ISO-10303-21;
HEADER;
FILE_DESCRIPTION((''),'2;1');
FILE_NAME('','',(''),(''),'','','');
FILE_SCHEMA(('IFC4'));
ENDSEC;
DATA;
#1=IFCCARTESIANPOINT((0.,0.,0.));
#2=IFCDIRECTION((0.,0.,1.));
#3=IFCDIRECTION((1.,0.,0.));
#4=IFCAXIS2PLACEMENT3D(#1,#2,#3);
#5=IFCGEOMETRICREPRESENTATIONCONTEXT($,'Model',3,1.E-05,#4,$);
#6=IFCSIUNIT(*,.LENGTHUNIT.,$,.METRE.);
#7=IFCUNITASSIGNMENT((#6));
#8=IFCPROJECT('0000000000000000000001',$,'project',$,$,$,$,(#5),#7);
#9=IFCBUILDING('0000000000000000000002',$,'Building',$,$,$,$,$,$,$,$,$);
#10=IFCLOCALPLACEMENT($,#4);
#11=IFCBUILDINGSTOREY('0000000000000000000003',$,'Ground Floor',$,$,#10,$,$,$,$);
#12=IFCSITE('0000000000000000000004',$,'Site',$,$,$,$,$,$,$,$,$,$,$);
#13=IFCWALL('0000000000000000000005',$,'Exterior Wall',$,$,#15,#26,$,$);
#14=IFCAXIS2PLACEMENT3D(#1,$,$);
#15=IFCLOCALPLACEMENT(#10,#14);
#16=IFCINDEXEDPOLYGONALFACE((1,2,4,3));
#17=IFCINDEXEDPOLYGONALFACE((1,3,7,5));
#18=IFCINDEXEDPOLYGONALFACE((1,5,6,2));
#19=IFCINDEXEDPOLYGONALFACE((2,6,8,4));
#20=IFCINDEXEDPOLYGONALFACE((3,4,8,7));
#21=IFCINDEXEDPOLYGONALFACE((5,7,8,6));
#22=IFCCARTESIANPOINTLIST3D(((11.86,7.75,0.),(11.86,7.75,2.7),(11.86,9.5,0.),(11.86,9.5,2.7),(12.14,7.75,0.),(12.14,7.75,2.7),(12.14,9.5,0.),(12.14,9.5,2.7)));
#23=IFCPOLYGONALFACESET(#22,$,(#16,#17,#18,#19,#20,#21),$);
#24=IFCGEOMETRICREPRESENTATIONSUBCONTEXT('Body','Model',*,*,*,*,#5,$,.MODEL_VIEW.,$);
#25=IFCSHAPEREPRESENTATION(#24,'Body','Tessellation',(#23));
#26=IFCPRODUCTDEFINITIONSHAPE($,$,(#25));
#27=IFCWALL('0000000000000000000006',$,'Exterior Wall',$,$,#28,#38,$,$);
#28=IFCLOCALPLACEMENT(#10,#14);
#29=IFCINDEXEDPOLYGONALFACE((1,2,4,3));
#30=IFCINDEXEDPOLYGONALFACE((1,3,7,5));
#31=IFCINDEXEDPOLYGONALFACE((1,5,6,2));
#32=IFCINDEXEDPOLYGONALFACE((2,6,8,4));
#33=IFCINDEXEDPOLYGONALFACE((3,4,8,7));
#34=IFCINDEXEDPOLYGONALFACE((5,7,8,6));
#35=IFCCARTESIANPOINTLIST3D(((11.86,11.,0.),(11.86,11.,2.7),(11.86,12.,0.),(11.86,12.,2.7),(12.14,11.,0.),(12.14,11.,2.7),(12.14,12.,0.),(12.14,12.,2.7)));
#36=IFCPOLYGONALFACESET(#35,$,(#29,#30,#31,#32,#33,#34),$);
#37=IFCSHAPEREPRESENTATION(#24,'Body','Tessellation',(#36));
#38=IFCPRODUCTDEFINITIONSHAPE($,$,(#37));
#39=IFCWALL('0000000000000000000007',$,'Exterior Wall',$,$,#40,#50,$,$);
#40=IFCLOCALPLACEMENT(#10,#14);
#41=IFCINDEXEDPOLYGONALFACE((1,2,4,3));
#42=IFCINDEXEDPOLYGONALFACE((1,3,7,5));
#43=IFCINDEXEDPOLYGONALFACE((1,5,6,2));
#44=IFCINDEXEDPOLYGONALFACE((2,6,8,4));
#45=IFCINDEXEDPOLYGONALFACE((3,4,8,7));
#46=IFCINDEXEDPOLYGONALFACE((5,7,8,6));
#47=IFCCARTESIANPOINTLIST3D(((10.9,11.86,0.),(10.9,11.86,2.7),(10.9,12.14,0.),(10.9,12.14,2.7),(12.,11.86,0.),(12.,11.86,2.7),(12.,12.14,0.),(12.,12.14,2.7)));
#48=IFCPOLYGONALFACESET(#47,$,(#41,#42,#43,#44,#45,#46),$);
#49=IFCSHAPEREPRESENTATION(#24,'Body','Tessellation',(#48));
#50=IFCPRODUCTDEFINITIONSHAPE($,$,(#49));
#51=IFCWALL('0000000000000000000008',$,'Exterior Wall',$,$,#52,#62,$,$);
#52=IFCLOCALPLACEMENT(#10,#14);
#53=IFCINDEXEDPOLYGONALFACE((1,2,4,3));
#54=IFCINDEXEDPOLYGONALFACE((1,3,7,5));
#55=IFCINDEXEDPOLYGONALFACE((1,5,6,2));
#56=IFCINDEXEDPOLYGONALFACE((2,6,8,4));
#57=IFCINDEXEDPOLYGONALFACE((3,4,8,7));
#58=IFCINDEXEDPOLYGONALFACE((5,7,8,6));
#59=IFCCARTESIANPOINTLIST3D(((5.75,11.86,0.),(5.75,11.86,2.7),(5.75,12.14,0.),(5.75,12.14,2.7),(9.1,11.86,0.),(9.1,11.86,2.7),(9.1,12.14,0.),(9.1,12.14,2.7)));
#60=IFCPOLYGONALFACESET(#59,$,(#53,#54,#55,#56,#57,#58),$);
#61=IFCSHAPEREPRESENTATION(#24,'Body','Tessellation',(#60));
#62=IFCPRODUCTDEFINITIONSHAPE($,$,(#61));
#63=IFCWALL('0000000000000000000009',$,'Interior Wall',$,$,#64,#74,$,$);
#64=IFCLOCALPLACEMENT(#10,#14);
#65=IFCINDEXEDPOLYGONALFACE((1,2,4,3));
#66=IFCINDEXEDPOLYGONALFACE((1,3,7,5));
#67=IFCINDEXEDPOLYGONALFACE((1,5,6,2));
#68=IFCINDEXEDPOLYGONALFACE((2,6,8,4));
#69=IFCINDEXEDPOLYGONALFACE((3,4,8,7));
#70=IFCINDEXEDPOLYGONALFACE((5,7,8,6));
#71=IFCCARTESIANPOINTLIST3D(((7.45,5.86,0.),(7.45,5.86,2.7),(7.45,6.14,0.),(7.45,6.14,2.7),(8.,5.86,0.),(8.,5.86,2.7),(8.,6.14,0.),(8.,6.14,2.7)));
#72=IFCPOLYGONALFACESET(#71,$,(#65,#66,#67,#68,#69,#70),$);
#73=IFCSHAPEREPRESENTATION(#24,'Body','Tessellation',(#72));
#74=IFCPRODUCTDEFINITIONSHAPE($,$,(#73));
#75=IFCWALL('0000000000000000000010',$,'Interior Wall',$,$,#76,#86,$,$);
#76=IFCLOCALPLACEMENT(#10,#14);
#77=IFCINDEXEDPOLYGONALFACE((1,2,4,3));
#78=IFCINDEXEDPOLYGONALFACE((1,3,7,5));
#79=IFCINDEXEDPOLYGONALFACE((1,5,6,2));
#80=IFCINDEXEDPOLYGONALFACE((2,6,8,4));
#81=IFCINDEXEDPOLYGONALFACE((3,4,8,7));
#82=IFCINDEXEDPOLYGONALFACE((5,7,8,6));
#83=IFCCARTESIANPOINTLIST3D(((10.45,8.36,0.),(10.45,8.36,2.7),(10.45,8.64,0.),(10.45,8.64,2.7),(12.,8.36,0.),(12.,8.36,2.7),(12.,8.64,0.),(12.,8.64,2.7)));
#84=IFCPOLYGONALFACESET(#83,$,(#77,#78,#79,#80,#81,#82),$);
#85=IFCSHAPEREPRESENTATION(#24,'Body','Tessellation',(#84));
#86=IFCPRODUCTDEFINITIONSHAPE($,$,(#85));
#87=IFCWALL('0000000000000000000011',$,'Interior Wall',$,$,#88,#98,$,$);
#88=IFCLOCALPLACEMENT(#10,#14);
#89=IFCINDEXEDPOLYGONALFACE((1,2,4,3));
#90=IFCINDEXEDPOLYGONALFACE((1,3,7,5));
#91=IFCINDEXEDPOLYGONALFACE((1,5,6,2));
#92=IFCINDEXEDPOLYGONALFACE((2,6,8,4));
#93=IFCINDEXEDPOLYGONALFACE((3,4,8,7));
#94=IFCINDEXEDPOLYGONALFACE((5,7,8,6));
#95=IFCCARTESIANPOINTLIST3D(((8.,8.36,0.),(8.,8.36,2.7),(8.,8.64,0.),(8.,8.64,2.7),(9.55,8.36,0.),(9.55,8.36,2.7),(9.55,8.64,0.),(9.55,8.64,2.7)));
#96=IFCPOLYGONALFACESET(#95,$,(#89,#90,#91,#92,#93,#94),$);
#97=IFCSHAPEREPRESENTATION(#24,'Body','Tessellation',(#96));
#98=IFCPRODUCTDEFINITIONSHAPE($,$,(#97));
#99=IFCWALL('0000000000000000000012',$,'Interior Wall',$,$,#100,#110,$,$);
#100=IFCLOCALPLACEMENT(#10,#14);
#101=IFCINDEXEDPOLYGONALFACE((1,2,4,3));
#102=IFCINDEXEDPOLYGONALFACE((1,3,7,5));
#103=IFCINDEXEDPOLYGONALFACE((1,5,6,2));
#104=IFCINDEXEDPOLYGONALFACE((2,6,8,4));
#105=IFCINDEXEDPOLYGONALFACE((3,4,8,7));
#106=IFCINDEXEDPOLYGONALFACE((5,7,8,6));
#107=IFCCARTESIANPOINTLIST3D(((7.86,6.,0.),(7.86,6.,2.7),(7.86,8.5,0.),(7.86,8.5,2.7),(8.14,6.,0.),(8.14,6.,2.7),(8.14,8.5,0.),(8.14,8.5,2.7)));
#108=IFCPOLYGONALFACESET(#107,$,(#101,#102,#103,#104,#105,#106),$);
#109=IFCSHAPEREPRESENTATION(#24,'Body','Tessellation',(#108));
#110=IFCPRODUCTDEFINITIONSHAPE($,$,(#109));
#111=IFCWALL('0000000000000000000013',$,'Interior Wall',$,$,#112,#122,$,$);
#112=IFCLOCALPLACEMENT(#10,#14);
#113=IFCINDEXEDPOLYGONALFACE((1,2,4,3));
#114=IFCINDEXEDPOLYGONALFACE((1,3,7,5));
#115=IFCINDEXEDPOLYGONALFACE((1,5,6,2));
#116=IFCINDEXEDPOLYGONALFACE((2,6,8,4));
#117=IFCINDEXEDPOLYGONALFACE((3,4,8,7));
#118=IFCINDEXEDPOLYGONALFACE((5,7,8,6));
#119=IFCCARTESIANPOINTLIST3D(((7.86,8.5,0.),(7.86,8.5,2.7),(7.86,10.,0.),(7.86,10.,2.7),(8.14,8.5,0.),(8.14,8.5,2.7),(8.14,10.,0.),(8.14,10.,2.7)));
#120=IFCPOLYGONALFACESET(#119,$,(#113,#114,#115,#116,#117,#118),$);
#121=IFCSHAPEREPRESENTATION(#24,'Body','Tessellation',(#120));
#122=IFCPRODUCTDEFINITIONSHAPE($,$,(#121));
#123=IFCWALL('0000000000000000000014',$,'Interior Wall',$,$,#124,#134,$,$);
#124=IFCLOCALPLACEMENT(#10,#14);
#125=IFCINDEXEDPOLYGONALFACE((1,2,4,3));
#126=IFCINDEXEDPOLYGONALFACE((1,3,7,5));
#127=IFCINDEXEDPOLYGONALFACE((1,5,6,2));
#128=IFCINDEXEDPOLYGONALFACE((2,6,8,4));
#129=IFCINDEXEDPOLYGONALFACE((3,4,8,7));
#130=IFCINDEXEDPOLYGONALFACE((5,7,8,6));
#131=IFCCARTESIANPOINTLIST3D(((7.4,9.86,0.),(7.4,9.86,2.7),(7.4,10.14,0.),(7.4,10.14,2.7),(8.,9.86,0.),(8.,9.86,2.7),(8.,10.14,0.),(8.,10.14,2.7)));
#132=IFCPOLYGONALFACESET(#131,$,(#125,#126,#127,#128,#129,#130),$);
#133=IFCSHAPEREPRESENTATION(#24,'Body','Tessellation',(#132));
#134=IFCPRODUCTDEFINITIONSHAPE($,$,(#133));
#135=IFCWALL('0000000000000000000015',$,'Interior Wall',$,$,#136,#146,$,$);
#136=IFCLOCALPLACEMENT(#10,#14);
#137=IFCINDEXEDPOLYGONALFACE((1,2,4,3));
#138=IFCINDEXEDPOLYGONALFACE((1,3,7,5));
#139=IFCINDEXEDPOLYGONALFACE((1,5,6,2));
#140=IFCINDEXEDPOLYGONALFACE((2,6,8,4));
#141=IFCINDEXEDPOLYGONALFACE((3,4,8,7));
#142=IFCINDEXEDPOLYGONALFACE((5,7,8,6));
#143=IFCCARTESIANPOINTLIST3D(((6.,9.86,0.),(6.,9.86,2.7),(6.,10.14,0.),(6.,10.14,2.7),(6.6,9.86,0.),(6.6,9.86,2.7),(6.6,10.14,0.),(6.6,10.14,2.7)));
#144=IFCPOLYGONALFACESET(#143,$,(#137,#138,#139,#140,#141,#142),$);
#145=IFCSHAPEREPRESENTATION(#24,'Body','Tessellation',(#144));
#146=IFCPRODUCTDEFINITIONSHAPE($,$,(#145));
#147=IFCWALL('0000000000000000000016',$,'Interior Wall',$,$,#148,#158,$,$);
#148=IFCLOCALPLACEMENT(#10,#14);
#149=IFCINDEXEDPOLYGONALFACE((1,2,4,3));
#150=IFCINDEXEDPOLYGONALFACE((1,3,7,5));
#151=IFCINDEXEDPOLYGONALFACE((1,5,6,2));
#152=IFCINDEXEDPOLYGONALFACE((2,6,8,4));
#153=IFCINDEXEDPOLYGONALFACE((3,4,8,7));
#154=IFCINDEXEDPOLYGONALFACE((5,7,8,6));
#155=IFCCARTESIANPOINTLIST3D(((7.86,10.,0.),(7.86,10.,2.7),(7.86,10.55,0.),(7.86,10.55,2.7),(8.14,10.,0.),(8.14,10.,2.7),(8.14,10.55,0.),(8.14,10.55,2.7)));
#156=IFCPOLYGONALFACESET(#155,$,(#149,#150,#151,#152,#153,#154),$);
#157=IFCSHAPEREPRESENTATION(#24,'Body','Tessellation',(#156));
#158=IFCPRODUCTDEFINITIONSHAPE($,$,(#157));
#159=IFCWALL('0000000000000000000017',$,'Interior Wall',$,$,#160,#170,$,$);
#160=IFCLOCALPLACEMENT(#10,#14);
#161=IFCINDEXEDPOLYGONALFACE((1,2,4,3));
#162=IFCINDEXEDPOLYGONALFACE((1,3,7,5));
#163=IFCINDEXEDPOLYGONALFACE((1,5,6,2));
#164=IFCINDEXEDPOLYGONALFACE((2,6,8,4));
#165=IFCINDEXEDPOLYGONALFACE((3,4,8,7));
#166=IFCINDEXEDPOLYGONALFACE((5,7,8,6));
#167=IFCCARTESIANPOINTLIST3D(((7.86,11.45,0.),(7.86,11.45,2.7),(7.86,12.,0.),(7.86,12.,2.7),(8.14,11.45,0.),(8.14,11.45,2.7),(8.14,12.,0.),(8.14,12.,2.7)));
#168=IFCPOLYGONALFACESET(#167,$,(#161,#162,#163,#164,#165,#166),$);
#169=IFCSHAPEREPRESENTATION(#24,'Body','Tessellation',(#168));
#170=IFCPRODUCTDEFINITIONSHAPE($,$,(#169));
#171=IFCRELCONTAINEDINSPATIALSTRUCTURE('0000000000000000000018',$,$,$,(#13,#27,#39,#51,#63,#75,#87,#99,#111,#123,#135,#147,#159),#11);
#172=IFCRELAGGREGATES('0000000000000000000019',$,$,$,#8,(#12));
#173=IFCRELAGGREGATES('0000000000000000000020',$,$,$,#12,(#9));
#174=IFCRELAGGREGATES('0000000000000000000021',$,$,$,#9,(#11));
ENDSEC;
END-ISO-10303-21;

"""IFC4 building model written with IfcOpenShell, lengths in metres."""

from ifc_helpers import new_model, si_unit, frame, origin_with_axes, place, context, subcontext, project, spatial, indexed_curve, outline, extrude, element, save


model = new_model("IFC4")

# Units and contexts
model_context = context("Model", 3, precision=1e-05, world=origin_with_axes())
body_context = subcontext(model_context, "Body", "Model", "MODEL_VIEW")
ifc_project = project(units=[si_unit("LENGTHUNIT", "METRE")], contexts=[model_context])

# Site, building, storey
site = spatial("IfcSite", under=ifc_project, Name="Site")
building = spatial("IfcBuilding", under=site, Name="Building")
storey_placement = place(None, origin_with_axes())
storey = spatial("IfcBuildingStorey", under=building, at=storey_placement, Name="Ground Floor")

# Walls
wall_1_placement = place(storey_placement, frame((12.0, 7.75, 0.0), z_axis=(0.0, 0.0, 1.0), x_axis=(0.0, 1.0, 0.0)))
element("IfcWall", 1, at=wall_1_placement, inside=storey, Name="Exterior Wall", context=body_context, shape_type="SweptSolid", body=[
    extrude(outline(indexed_curve([(0.0, 0.0), (0.0, 0.28), (1.75, 0.28), (1.75, 0.0), (0.0, 0.0)], self_intersect=False)), frame((0.0, -0.14, 0.0), z_axis=(0.0, 0.0, 1.0), x_axis=(1.0, 0.0, 0.0)), (0.0, 0.0, 1.0), 2.7),
])
wall_2_placement = place(storey_placement, frame((12.0, 11.0, 0.0), z_axis=(0.0, 0.0, 1.0), x_axis=(0.0, 1.0, 0.0)))
element("IfcWall", 2, at=wall_2_placement, inside=storey, Name="Exterior Wall", context=body_context, shape_type="SweptSolid", body=[
    extrude(outline(indexed_curve([(0.0, 0.0), (0.0, 0.28), (1.0, 0.28), (1.0, 0.0), (0.0, 0.0)], self_intersect=False)), frame((0.0, -0.14, 0.0), z_axis=(0.0, 0.0, 1.0), x_axis=(1.0, 0.0, 0.0)), (0.0, 0.0, 1.0), 2.7),
])
wall_3_placement = place(storey_placement, frame((12.0, 12.0, 0.0), z_axis=(0.0, 0.0, 1.0), x_axis=(-1.0, 0.0, 0.0)))
element("IfcWall", 3, at=wall_3_placement, inside=storey, Name="Exterior Wall", context=body_context, shape_type="SweptSolid", body=[
    extrude(outline(indexed_curve([(0.0, 0.0), (0.0, 0.28), (1.1, 0.28), (1.1, 0.0), (0.0, 0.0)], self_intersect=False)), frame((0.0, -0.14, 0.0), z_axis=(0.0, 0.0, 1.0), x_axis=(1.0, 0.0, 0.0)), (0.0, 0.0, 1.0), 2.7),
])
wall_4_placement = place(storey_placement, frame((9.1, 12.0, 0.0), z_axis=(0.0, 0.0, 1.0), x_axis=(-1.0, 0.0, 0.0)))
element("IfcWall", 4, at=wall_4_placement, inside=storey, Name="Exterior Wall", context=body_context, shape_type="SweptSolid", body=[
    extrude(outline(indexed_curve([(0.0, 0.0), (0.0, 0.28), (3.35, 0.28), (3.35, 0.0), (0.0, 0.0)], self_intersect=False)), frame((0.0, -0.14, 0.0), z_axis=(0.0, 0.0, 1.0), x_axis=(1.0, 0.0, 0.0)), (0.0, 0.0, 1.0), 2.7),
])
wall_5_placement = place(storey_placement, frame((8.0, 6.0, 0.0), z_axis=(0.0, 0.0, 1.0), x_axis=(-1.0, 0.0, 0.0)))
element("IfcWall", 5, at=wall_5_placement, inside=storey, Name="Interior Wall", context=body_context, shape_type="SweptSolid", body=[
    extrude(outline(indexed_curve([(0.0, 0.0), (0.0, 0.28), (0.55, 0.28), (0.55, 0.0), (0.0, 0.0)], self_intersect=False)), frame((0.0, -0.14, 0.0), z_axis=(0.0, 0.0, 1.0), x_axis=(1.0, 0.0, 0.0)), (0.0, 0.0, 1.0), 2.7),
])
for number, where, z_axis, x_axis, name in (
    (6, (12.0, 8.5, 0.0), (0.0, 0.0, 1.0), (-1.0, 0.0, 0.0), "Interior Wall"),
    (7, (9.55, 8.5, 0.0), (0.0, 0.0, 1.0), (-1.0, 0.0, 0.0), "Interior Wall"),
):
    element("IfcWall", number, at=place(storey_placement, frame(where, z_axis=z_axis, x_axis=x_axis)), inside=storey, Name=name, context=body_context, shape_type="SweptSolid", body=[
        extrude(outline(indexed_curve([(0.0, 0.0), (0.0, 0.28), (1.55, 0.28), (1.55, 0.0), (0.0, 0.0)], self_intersect=False)), frame((0.0, -0.14, 0.0), z_axis=(0.0, 0.0, 1.0), x_axis=(1.0, 0.0, 0.0)), (0.0, 0.0, 1.0), 2.7),
    ])
wall_6_placement = place(storey_placement, frame((8.0, 8.5, 0.0), z_axis=(0.0, 0.0, 1.0), x_axis=(0.0, -1.0, 0.0)))
element("IfcWall", 8, at=wall_6_placement, inside=storey, Name="Interior Wall", context=body_context, shape_type="SweptSolid", body=[
    extrude(outline(indexed_curve([(0.0, 0.0), (0.0, 0.28), (2.5, 0.28), (2.5, 0.0), (0.0, 0.0)], self_intersect=False)), frame((0.0, -0.14, 0.0), z_axis=(0.0, 0.0, 1.0), x_axis=(1.0, 0.0, 0.0)), (0.0, 0.0, 1.0), 2.7),
])
wall_7_placement = place(storey_placement, frame((8.0, 8.5, 0.0), z_axis=(0.0, 0.0, 1.0), x_axis=(0.0, 1.0, 0.0)))
element("IfcWall", 9, at=wall_7_placement, inside=storey, Name="Interior Wall", context=body_context, shape_type="SweptSolid", body=[
    extrude(outline(indexed_curve([(0.0, 0.0), (0.0, 0.28), (1.5, 0.28), (1.5, 0.0), (0.0, 0.0)], self_intersect=False)), frame((0.0, -0.14, 0.0), z_axis=(0.0, 0.0, 1.0), x_axis=(1.0, 0.0, 0.0)), (0.0, 0.0, 1.0), 2.7),
])
for number, where, z_axis, x_axis, name in (
    (10, (8.0, 10.0, 0.0), (0.0, 0.0, 1.0), (-1.0, 0.0, 0.0), "Interior Wall"),
    (11, (6.6, 10.0, 0.0), (0.0, 0.0, 1.0), (-1.0, 0.0, 0.0), "Interior Wall"),
):
    element("IfcWall", number, at=place(storey_placement, frame(where, z_axis=z_axis, x_axis=x_axis)), inside=storey, Name=name, context=body_context, shape_type="SweptSolid", body=[
        extrude(outline(indexed_curve([(0.0, 0.0), (0.0, 0.28), (0.6, 0.28), (0.6, 0.0), (0.0, 0.0)], self_intersect=False)), frame((0.0, -0.14, 0.0), z_axis=(0.0, 0.0, 1.0), x_axis=(1.0, 0.0, 0.0)), (0.0, 0.0, 1.0), 2.7),
    ])
for number, where, z_axis, x_axis, name in (
    (12, (8.0, 10.0, 0.0), (0.0, 0.0, 1.0), (0.0, 1.0, 0.0), "Interior Wall"),
    (13, (8.0, 11.45, 0.0), (0.0, 0.0, 1.0), (0.0, 1.0, 0.0), "Interior Wall"),
):
    element("IfcWall", number, at=place(storey_placement, frame(where, z_axis=z_axis, x_axis=x_axis)), inside=storey, Name=name, context=body_context, shape_type="SweptSolid", body=[
        extrude(outline(indexed_curve([(0.0, 0.0), (0.0, 0.28), (0.55, 0.28), (0.55, 0.0), (0.0, 0.0)], self_intersect=False)), frame((0.0, -0.14, 0.0), z_axis=(0.0, 0.0, 1.0), x_axis=(1.0, 0.0, 0.0)), (0.0, 0.0, 1.0), 2.7),
    ])

save(model, "model.ifc")
